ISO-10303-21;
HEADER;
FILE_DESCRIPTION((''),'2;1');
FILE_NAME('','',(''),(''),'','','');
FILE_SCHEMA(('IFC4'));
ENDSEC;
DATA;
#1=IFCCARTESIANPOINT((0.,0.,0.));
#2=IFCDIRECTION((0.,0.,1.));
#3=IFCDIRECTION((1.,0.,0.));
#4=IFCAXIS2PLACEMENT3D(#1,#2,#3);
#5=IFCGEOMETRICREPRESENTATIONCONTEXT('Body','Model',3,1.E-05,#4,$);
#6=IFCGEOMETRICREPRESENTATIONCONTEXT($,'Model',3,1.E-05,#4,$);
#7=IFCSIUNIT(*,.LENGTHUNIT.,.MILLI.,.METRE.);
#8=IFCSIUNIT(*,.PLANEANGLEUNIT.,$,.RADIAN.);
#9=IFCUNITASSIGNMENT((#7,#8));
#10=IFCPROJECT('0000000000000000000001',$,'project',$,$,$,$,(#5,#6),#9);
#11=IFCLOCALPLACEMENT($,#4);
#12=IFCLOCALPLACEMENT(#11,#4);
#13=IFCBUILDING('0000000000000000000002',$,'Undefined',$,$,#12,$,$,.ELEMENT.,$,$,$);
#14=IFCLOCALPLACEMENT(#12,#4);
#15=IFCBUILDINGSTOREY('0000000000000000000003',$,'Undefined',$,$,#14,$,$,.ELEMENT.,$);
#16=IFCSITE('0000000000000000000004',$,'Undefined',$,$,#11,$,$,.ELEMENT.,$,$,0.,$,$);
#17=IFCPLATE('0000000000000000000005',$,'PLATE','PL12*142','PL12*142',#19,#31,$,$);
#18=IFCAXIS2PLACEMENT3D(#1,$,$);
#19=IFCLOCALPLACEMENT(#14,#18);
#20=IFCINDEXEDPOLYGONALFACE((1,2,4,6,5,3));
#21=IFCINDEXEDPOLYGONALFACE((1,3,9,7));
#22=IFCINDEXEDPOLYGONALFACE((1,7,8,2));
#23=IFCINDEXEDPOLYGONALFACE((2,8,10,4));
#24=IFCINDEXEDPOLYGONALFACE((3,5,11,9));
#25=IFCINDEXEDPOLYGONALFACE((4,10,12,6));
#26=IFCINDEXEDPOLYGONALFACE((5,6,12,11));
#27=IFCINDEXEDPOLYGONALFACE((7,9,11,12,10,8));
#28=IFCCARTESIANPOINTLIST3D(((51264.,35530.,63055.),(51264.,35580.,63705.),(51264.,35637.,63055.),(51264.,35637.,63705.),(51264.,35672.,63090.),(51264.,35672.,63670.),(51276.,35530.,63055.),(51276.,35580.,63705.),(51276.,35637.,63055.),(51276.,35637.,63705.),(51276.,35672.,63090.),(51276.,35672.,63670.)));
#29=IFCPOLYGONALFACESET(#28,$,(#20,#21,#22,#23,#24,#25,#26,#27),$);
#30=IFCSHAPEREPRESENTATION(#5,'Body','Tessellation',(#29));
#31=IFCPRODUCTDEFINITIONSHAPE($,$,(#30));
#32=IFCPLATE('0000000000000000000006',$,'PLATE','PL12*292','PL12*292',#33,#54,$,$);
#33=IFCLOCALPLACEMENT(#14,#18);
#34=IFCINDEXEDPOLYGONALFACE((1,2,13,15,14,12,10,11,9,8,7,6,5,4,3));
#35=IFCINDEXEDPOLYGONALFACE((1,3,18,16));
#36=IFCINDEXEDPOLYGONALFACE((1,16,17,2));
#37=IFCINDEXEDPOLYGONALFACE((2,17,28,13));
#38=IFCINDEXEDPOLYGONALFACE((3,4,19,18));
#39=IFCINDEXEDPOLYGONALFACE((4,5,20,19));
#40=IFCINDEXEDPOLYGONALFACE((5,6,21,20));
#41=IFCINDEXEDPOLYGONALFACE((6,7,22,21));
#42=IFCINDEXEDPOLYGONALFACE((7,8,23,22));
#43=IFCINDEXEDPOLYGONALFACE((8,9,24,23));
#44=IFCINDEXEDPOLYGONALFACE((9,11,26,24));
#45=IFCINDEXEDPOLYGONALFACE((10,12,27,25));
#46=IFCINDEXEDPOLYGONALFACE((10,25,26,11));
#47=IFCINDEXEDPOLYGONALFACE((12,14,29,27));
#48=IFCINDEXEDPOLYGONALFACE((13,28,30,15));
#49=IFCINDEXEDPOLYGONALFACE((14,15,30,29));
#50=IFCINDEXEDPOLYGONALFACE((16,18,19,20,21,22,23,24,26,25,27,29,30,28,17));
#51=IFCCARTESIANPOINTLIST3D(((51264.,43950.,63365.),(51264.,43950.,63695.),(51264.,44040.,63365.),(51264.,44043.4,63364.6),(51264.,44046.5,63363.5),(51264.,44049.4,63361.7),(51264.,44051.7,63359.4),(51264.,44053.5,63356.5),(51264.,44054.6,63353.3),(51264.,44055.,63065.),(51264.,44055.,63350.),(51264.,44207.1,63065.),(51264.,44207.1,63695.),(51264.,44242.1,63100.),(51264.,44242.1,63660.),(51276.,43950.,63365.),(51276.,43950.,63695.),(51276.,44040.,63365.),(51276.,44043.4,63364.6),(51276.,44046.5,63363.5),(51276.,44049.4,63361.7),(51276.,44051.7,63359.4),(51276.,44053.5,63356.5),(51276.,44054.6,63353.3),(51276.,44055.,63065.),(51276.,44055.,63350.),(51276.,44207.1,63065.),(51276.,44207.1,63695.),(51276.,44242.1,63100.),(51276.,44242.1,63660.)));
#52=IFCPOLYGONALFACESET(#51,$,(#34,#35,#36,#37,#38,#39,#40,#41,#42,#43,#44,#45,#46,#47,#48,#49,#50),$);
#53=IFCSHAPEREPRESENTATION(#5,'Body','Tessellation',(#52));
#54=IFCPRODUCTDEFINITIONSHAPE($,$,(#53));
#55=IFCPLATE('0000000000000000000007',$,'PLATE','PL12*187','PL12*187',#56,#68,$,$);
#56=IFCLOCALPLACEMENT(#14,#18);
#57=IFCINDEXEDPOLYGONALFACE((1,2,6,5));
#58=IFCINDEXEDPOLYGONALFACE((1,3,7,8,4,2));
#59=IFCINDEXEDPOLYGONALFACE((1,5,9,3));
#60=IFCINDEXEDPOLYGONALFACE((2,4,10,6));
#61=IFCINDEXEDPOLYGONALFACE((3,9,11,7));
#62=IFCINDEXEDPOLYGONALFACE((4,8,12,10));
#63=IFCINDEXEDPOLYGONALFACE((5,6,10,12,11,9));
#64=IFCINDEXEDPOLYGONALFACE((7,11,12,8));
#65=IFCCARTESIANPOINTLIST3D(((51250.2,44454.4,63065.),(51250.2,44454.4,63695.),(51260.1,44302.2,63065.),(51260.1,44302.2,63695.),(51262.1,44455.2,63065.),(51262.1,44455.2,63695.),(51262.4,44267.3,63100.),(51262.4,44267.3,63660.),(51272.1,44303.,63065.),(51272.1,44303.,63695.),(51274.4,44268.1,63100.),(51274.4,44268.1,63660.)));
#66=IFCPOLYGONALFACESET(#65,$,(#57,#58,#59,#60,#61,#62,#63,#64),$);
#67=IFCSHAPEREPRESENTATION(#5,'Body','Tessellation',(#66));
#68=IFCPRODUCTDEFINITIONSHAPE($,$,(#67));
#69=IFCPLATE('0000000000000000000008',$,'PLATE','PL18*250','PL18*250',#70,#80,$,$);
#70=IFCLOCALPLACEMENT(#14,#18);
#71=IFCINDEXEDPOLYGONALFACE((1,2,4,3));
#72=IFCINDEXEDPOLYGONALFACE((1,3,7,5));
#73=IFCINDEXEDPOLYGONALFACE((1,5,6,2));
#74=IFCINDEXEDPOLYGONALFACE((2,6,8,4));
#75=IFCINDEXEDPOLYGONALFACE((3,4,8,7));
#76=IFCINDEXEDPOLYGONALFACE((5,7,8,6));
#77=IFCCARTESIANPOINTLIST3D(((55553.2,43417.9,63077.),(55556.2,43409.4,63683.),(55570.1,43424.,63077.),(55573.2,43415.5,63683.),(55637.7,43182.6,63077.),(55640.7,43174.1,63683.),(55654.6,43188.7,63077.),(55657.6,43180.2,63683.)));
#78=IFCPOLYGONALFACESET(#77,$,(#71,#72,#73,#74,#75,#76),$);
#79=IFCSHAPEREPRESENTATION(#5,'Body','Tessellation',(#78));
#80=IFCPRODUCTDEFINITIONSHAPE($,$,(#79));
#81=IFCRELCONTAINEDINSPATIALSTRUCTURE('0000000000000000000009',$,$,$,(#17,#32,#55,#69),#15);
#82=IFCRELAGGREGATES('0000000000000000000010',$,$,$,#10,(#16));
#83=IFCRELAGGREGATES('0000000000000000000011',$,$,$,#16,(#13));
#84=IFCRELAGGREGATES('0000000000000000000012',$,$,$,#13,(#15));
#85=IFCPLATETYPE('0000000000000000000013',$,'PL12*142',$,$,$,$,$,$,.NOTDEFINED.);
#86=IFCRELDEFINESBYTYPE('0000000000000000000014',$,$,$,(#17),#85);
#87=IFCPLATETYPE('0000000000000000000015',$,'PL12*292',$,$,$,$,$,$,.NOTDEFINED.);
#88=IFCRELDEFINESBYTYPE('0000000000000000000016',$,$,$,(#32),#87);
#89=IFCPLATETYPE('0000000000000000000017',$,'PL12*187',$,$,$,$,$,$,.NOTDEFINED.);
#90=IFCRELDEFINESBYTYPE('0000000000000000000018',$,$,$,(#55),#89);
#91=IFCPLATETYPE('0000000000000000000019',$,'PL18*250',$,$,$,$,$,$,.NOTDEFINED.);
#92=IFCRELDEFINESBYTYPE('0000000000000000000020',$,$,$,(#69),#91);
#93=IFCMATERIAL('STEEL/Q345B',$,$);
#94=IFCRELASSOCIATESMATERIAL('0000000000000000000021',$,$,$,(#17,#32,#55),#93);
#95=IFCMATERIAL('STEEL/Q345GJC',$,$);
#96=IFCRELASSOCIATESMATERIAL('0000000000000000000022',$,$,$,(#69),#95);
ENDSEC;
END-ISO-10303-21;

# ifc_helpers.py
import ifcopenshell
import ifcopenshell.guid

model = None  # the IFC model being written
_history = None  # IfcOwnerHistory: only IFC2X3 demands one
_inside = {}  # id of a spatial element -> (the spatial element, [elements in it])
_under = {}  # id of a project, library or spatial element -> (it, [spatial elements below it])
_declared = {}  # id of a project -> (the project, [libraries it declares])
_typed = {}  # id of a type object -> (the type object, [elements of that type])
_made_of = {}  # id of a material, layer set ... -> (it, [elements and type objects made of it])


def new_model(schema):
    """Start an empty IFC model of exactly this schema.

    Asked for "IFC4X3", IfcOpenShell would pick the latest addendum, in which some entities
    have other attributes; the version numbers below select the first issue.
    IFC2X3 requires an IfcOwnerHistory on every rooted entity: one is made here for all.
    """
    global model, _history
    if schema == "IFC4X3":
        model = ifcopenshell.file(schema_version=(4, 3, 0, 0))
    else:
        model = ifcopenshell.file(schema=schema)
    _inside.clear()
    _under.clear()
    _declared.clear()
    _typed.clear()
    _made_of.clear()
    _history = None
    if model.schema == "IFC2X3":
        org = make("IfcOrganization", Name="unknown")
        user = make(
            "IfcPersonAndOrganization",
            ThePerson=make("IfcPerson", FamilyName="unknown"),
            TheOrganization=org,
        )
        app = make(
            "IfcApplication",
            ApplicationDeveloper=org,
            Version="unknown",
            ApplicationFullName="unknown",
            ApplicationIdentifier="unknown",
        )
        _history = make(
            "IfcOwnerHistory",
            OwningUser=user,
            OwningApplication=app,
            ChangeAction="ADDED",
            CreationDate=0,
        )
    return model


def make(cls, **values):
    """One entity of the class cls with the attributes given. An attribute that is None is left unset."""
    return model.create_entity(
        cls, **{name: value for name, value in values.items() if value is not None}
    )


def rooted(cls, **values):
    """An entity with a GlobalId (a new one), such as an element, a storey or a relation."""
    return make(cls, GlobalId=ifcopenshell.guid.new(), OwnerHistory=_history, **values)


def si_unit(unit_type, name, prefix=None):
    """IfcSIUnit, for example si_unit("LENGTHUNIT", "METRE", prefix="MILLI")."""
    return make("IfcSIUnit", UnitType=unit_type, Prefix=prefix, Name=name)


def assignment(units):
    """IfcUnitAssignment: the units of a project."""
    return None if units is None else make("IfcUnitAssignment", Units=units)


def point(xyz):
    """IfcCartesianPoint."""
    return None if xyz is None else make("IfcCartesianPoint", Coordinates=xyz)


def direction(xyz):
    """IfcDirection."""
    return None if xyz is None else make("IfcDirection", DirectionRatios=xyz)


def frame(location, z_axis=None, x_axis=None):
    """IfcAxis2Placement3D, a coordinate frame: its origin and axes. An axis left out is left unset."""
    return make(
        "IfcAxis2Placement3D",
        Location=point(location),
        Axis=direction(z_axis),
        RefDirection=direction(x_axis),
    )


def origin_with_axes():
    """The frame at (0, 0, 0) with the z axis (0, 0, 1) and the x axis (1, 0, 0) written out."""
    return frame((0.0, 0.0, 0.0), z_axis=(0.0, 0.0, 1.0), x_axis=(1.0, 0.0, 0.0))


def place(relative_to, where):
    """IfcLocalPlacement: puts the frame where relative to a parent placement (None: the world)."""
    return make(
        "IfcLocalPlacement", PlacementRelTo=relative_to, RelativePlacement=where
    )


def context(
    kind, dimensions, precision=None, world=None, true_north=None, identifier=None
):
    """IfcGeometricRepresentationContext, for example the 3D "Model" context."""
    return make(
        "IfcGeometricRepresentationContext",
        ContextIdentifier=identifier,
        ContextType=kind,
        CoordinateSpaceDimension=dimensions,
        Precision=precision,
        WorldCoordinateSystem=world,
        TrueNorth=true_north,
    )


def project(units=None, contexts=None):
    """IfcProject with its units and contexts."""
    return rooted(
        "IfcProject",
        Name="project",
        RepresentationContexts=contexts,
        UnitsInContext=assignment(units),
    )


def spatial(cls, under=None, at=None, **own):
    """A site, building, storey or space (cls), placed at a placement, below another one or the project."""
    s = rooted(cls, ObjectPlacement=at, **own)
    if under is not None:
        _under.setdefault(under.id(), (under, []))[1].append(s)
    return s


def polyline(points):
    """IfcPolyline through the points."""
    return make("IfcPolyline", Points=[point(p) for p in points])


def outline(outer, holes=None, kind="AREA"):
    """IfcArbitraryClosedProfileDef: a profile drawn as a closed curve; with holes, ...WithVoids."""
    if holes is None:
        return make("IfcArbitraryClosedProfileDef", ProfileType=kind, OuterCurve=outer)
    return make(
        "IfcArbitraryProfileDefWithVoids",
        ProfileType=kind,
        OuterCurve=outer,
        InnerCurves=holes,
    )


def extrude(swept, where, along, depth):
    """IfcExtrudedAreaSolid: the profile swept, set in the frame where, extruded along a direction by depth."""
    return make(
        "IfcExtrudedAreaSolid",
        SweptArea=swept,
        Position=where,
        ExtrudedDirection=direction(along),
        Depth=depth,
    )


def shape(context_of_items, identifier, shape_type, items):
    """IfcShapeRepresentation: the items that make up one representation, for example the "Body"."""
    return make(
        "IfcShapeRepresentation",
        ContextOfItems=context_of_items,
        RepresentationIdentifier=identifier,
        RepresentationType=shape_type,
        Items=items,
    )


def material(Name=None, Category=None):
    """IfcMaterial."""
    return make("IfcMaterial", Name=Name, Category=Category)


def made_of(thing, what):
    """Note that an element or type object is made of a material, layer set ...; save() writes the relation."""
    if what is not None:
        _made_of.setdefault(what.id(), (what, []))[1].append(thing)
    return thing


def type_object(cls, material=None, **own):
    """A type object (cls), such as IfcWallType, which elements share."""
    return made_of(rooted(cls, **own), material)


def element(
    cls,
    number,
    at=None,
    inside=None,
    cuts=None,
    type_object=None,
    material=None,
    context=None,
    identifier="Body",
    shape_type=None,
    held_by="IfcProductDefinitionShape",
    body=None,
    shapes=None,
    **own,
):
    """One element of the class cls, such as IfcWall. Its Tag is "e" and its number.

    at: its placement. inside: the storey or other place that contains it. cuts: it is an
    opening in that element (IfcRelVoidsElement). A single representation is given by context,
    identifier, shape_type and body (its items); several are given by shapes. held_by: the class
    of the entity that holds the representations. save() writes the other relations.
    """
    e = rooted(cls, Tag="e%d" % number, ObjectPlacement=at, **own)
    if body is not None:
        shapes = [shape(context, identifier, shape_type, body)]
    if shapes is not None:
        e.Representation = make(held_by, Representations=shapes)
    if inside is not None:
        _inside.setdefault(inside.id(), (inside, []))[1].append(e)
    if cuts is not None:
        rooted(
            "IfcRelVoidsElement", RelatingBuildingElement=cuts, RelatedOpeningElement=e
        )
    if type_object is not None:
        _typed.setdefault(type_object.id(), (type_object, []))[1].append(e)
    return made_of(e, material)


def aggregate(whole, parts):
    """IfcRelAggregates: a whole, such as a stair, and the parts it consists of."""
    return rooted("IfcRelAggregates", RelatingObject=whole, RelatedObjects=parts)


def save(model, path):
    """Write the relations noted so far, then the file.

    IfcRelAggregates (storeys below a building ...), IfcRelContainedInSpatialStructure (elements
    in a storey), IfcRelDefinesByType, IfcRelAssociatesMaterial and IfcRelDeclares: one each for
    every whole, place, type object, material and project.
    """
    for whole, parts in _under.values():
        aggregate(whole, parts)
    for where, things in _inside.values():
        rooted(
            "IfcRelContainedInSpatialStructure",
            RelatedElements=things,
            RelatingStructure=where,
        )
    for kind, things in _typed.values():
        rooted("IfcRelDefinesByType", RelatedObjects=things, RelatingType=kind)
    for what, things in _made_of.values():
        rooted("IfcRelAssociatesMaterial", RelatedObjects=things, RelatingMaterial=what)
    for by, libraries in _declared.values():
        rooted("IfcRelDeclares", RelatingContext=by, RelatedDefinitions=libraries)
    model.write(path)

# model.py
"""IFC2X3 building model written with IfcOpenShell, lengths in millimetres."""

from ifc_helpers import new_model, si_unit, frame, origin_with_axes, place, context, project, spatial, polyline, outline, extrude, material, type_object, element, save


model = new_model("IFC2X3")

# Units and contexts
model_context_1 = context("Model", 3, precision=1e-05, world=origin_with_axes(), identifier="Body")
model_context_2 = context("Model", 3, precision=1e-05, world=origin_with_axes())
ifc_project = project(units=[si_unit("LENGTHUNIT", "METRE", prefix="MILLI"), si_unit("PLANEANGLEUNIT", "RADIAN")], contexts=[model_context_1, model_context_2])

# Site, building, storey
site_placement = place(None, origin_with_axes())
site = spatial("IfcSite", under=ifc_project, at=site_placement, Name="Undefined", CompositionType="ELEMENT", RefElevation=0.0)
building_placement = place(site_placement, origin_with_axes())
building = spatial("IfcBuilding", under=site, at=building_placement, Name="Undefined", CompositionType="ELEMENT")
storey_placement = place(building_placement, origin_with_axes())
storey = spatial("IfcBuildingStorey", under=building, at=storey_placement, Name="Undefined", CompositionType="ELEMENT")

# Shared definitions
ifc_material_1 = material(Name="STEEL/Q345B")
ifc_material_2 = material(Name="STEEL/Q345GJC")

# Plates
plate_type_1 = type_object("IfcPlateType", Name="PL12*142", PredefinedType="NOTDEFINED")
for number, where, z_axis, x_axis, name in (
    (1, (51270.0, 35530.0, 63055.0), (1.0, 0.0, 0.0), (0.0, 1.0, 0.0), "PLATE"),
):
    element("IfcPlate", number, at=place(storey_placement, frame(where, z_axis=z_axis, x_axis=x_axis)), inside=storey, type_object=plate_type_1, material=ifc_material_1, Name=name, Description="PL12*142", ObjectType="PL12*142", context=model_context_1, shape_type="SweptSolid", body=[
        extrude(outline(polyline([(0.0, 0.0), (107.0, 0.0), (142.0, 35.0), (142.0, 615.0), (107.0, 650.0), (50.0, 650.0), (0.0, 0.0)])), frame((0.0, 0.0, -6.0), z_axis=(0.0, 0.0, 1.0), x_axis=(1.0, 0.0, 0.0)), (0.0, 0.0, 1.0), 12.0),
    ])
plate_type_2 = type_object("IfcPlateType", Name="PL12*292", PredefinedType="NOTDEFINED")
plate_1_placement = place(storey_placement, frame((51270.0, 43950.0, 63695.0), z_axis=(-1.0, 0.0, 0.0), x_axis=(0.0, 1.0, 0.0)))
element("IfcPlate", 2, at=plate_1_placement, inside=storey, type_object=plate_type_2, material=ifc_material_1, Name="PLATE", Description="PL12*292", ObjectType="PL12*292", context=model_context_1, shape_type="SweptSolid", body=[
    extrude(outline(polyline([(0.0, 0.0), (257.2, 0.0), (292.2, 35.0), (292.2, 595.0), (257.2, 630.0), (105.1, 630.0), (105.1, 345.0), (104.7, 341.7), (103.6, 338.5), (101.8, 335.6), (99.4, 333.3), (96.6, 331.5), (93.4, 330.4), (90.1, 330.0), (0.0, 330.0), (0.0, 0.0)])), frame((0.0, 0.0, -6.0), z_axis=(0.0, 0.0, 1.0), x_axis=(1.0, 0.0, 0.0)), (0.0, 0.0, 1.0), 12.0),
])
plate_type_3 = type_object("IfcPlateType", Name="PL12*187", PredefinedType="NOTDEFINED")
plate_2_placement = place(storey_placement, frame((51268.4, 44267.7, 63065.0), z_axis=(0.997873, 0.065184, 0.0), x_axis=(-0.065184, 0.997873, 0.0)))
element("IfcPlate", 3, at=plate_2_placement, inside=storey, type_object=plate_type_3, material=ifc_material_1, Name="PLATE", Description="PL12*187", ObjectType="PL12*187", context=model_context_1, shape_type="SweptSolid", body=[
    extrude(outline(polyline([(0.0, 35.0), (35.0, 0.0), (187.5, 0.0), (187.5, 630.0), (35.0, 630.0), (0.0, 595.0), (0.0, 35.0)])), frame((0.0, 0.0, -6.0), z_axis=(0.0, 0.0, 1.0), x_axis=(1.0, 0.0, 0.0)), (0.0, 0.0, 1.0), 12.0),
])
plate_type_4 = type_object("IfcPlateType", Name="PL18*250", PredefinedType="NOTDEFINED")
plate_3_placement = place(storey_placement, frame((55649.2, 43177.1, 63683.0), z_axis=(-0.941212, -0.337816, 0.0), x_axis=(-0.337816, 0.941212, 0.0)))
element("IfcPlate", 4, at=plate_3_placement, inside=storey, type_object=plate_type_4, material=ifc_material_2, Name="PLATE", Description="PL18*250", ObjectType="PL18*250", context=model_context_1, shape_type="SweptSolid", body=[
    extrude(outline(polyline([(0.0, 0.0), (250.0, 0.0), (259.0, 606.0), (9.0, 606.0), (0.0, 0.0)])), frame((0.0, 0.0, -9.0), z_axis=(0.0, 0.0, 1.0), x_axis=(1.0, 0.0, 0.0)), (0.0, 0.0, 1.0), 18.0),
])

save(model, "model.ifc")
